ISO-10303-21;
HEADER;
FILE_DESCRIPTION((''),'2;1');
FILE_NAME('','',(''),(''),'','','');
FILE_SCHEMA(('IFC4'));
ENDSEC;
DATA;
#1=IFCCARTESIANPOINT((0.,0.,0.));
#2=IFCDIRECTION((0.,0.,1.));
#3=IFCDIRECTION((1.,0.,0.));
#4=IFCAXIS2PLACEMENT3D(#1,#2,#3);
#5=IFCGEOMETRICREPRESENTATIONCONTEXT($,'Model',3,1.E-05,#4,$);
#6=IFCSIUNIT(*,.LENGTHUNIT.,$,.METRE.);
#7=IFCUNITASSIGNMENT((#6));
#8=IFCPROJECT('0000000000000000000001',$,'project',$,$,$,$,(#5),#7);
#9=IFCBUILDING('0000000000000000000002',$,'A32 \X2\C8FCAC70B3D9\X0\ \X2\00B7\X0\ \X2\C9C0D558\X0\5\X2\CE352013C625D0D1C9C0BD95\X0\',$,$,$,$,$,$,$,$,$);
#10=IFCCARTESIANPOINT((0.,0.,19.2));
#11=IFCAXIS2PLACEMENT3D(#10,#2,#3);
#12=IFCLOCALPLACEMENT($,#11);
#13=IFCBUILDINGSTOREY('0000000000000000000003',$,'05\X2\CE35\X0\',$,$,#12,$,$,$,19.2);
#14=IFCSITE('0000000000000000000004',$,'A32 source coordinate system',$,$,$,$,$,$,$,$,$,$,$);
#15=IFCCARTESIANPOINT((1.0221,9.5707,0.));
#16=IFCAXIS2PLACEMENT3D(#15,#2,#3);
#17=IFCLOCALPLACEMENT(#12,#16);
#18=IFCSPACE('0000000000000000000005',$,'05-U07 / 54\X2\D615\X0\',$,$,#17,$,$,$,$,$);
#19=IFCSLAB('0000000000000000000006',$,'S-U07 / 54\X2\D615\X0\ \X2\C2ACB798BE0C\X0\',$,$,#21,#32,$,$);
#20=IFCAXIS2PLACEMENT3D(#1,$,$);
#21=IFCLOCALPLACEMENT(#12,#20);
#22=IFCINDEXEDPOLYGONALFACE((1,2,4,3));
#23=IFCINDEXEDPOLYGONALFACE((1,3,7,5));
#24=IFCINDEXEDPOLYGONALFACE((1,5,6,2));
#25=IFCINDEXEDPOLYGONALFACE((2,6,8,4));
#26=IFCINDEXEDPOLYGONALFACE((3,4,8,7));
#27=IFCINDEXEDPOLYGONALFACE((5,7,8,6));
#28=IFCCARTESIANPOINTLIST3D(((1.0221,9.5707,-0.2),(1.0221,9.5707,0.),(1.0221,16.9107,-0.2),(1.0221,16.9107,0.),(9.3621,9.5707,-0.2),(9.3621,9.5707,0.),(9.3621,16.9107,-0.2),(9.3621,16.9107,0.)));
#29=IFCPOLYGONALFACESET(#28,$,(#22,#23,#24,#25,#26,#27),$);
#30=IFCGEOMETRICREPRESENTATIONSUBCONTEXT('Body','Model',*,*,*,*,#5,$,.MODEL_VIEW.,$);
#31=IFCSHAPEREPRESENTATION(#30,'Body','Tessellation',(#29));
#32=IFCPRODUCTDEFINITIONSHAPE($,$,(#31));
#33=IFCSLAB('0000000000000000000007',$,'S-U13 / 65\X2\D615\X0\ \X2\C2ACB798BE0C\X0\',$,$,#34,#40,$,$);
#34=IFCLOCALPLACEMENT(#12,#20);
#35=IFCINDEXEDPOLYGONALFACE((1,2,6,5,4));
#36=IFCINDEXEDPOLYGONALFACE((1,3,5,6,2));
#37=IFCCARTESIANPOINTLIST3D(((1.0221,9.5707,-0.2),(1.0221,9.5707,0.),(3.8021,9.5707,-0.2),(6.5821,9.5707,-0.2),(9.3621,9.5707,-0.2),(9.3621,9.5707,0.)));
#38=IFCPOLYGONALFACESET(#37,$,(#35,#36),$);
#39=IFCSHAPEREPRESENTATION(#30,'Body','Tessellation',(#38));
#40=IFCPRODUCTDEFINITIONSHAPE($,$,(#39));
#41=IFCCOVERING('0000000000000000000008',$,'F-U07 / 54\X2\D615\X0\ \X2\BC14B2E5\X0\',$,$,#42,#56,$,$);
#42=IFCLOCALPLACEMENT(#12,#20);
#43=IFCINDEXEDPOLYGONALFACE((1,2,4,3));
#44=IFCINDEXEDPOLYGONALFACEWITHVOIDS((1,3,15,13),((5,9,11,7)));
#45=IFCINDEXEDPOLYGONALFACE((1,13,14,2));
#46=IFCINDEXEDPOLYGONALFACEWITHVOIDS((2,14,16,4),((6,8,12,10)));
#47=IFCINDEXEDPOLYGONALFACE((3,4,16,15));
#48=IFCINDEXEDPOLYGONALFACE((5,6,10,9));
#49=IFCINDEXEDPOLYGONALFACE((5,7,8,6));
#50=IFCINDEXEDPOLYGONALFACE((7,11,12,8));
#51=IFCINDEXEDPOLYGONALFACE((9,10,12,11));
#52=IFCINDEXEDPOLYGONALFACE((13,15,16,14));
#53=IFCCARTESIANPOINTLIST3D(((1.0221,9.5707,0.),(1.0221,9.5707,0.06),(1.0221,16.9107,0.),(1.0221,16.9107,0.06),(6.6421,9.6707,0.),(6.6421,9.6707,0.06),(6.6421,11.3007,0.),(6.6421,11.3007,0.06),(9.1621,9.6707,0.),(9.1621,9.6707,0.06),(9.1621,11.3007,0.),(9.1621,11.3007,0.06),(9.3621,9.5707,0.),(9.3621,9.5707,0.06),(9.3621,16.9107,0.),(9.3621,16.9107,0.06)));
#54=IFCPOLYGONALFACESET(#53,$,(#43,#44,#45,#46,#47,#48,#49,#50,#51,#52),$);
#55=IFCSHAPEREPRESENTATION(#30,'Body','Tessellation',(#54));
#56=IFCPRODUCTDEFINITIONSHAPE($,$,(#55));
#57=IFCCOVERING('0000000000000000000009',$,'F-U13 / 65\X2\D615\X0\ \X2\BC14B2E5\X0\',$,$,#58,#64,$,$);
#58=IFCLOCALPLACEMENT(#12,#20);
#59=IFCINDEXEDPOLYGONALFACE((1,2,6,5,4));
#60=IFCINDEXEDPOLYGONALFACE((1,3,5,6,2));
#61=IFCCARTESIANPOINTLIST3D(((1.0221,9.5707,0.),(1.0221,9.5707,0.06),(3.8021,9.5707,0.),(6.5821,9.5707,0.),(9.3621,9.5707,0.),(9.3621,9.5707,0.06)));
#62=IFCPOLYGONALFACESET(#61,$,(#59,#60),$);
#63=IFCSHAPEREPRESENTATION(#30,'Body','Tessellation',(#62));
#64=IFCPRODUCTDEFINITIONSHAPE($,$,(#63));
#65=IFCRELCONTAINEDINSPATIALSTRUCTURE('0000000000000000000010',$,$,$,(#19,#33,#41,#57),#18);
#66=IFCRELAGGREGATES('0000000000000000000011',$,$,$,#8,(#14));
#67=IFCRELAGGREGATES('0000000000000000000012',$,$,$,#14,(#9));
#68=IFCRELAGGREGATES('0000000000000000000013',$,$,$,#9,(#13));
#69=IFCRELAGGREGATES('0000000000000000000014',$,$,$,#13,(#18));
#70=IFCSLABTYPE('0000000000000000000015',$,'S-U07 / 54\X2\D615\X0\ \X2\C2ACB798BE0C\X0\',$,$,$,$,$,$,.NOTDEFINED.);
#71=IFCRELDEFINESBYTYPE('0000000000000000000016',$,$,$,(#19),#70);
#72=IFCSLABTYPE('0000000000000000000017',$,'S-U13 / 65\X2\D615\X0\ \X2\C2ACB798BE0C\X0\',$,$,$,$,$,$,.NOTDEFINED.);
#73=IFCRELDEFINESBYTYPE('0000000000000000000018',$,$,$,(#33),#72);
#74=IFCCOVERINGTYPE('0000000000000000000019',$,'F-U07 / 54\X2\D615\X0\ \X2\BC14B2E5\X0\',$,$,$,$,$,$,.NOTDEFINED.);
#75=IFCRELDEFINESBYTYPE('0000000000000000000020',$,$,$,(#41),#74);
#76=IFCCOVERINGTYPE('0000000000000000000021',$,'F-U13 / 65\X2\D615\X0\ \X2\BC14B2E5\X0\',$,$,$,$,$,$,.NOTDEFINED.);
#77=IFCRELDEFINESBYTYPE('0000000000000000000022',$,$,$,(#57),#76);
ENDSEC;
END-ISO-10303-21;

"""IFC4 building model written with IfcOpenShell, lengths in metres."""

from ifc_helpers import new_model, si_unit, frame, origin, origin_with_axes, place, context, subcontext, project, spatial, polyline, outline, extrude, source, transform, mapped, type_object, type_shapes, element, save


model = new_model("IFC4")

# Units and contexts
model_context = context("Model", 3, precision=1e-05, world=origin_with_axes())
body_context = subcontext(model_context, "Body", "Model", "MODEL_VIEW")
ifc_project = project(units=[si_unit("LENGTHUNIT", "METRE")], contexts=[model_context])

# Site, building, storey, space
storey_placement = place(None, frame((0.0, 0.0, 19.2), z_axis=(0.0, 0.0, 1.0), x_axis=(1.0, 0.0, 0.0)))
space_placement = place(storey_placement, frame((1.0221, 9.5707, 0.0), z_axis=(0.0, 0.0, 1.0), x_axis=(1.0, 0.0, 0.0)))
site = spatial("IfcSite", under=ifc_project, Name="A32 source coordinate system")
building = spatial("IfcBuilding", under=site, Name="A32 주거동 · 지하5층–옥탑지붕")
storey = spatial("IfcBuildingStorey", under=building, at=storey_placement, Name="05층", Elevation=19.2)
space = spatial("IfcSpace", under=storey, at=space_placement, Name="05-U07 / 54형")

# Slabs
slab_type_1 = type_object("IfcSlabType", Name="S-U07 / 54형 슬래브", PredefinedType="NOTDEFINED")
shared_shape_1 = source(origin(), body_context, "Body", "SweptSolid", [
    extrude(outline(polyline([(0.0, 0.0), (0.0, 7.34), (8.34, 7.34), (8.34, 0.0), (0.0, 0.0)])), frame((0.0, 0.0, -0.2)), (0.0, 0.0, 1.0), 0.2),
])
type_shapes(slab_type_1, [shared_shape_1])
slab_1_placement = place(space_placement, origin_with_axes())
element("IfcSlab", 1, at=slab_1_placement, inside=space, type_object=slab_type_1, Name="S-U07 / 54형 슬래브", context=body_context, shape_type="MappedRepresentation", body=[
    mapped(shared_shape_1, transform((0.0, 0.0, 0.0), scale=1.0)),
])
slab_type_2 = type_object("IfcSlabType", Name="S-U13 / 65형 슬래브", PredefinedType="NOTDEFINED")
shared_shape_2 = source(origin(), body_context, "Body", "SweptSolid", [
    extrude(outline(polyline([(0.0, 0.0), (8.34, 0.0), (8.34, 0.0), (0.0, 0.0), (0.0, 0.0)])), frame((0.0, 0.0, -0.2)), (0.0, 0.0, 1.0), 0.2),
])
type_shapes(slab_type_2, [shared_shape_2])
slab_2_placement = place(space_placement, origin_with_axes())
element("IfcSlab", 2, at=slab_2_placement, inside=space, type_object=slab_type_2, Name="S-U13 / 65형 슬래브", context=body_context, shape_type="MappedRepresentation", body=[
    mapped(shared_shape_2, transform((0.0, 0.0, 0.0), scale=1.0)),
])

# Coverings
covering_type_1 = type_object("IfcCoveringType", Name="F-U07 / 54형 바닥", PredefinedType="NOTDEFINED")
shared_shape_3 = source(origin(), body_context, "Body", "SweptSolid", [
    extrude(outline(polyline([(0.0, 0.0), (0.0, 7.34), (8.34, 7.34), (8.34, 0.0), (0.0, 0.0)]), holes=[polyline([(5.62, 1.73), (5.62, 0.1), (8.14, 0.1), (8.14, 1.73), (5.62, 1.73)])]), origin(), (0.0, 0.0, 1.0), 0.06),
])
type_shapes(covering_type_1, [shared_shape_3])
covering_1_placement = place(space_placement, origin_with_axes())
element("IfcCovering", 3, at=covering_1_placement, inside=space, type_object=covering_type_1, Name="F-U07 / 54형 바닥", context=body_context, shape_type="MappedRepresentation", body=[
    mapped(shared_shape_3, transform((0.0, 0.0, 0.0), scale=1.0)),
])
covering_type_2 = type_object("IfcCoveringType", Name="F-U13 / 65형 바닥", PredefinedType="NOTDEFINED")
shared_shape_4 = source(origin(), body_context, "Body", "SweptSolid", [
    extrude(outline(polyline([(0.0, 0.0), (8.34, 0.0), (8.34, 0.0), (0.0, 0.0), (0.0, 0.0)])), origin(), (0.0, 0.0, 1.0), 0.06),
])
type_shapes(covering_type_2, [shared_shape_4])
covering_2_placement = place(space_placement, origin_with_axes())
element("IfcCovering", 4, at=covering_2_placement, inside=space, type_object=covering_type_2, Name="F-U13 / 65형 바닥", context=body_context, shape_type="MappedRepresentation", body=[
    mapped(shared_shape_4, transform((0.0, 0.0, 0.0), scale=1.0)),
])

save(model, "model.ifc")
